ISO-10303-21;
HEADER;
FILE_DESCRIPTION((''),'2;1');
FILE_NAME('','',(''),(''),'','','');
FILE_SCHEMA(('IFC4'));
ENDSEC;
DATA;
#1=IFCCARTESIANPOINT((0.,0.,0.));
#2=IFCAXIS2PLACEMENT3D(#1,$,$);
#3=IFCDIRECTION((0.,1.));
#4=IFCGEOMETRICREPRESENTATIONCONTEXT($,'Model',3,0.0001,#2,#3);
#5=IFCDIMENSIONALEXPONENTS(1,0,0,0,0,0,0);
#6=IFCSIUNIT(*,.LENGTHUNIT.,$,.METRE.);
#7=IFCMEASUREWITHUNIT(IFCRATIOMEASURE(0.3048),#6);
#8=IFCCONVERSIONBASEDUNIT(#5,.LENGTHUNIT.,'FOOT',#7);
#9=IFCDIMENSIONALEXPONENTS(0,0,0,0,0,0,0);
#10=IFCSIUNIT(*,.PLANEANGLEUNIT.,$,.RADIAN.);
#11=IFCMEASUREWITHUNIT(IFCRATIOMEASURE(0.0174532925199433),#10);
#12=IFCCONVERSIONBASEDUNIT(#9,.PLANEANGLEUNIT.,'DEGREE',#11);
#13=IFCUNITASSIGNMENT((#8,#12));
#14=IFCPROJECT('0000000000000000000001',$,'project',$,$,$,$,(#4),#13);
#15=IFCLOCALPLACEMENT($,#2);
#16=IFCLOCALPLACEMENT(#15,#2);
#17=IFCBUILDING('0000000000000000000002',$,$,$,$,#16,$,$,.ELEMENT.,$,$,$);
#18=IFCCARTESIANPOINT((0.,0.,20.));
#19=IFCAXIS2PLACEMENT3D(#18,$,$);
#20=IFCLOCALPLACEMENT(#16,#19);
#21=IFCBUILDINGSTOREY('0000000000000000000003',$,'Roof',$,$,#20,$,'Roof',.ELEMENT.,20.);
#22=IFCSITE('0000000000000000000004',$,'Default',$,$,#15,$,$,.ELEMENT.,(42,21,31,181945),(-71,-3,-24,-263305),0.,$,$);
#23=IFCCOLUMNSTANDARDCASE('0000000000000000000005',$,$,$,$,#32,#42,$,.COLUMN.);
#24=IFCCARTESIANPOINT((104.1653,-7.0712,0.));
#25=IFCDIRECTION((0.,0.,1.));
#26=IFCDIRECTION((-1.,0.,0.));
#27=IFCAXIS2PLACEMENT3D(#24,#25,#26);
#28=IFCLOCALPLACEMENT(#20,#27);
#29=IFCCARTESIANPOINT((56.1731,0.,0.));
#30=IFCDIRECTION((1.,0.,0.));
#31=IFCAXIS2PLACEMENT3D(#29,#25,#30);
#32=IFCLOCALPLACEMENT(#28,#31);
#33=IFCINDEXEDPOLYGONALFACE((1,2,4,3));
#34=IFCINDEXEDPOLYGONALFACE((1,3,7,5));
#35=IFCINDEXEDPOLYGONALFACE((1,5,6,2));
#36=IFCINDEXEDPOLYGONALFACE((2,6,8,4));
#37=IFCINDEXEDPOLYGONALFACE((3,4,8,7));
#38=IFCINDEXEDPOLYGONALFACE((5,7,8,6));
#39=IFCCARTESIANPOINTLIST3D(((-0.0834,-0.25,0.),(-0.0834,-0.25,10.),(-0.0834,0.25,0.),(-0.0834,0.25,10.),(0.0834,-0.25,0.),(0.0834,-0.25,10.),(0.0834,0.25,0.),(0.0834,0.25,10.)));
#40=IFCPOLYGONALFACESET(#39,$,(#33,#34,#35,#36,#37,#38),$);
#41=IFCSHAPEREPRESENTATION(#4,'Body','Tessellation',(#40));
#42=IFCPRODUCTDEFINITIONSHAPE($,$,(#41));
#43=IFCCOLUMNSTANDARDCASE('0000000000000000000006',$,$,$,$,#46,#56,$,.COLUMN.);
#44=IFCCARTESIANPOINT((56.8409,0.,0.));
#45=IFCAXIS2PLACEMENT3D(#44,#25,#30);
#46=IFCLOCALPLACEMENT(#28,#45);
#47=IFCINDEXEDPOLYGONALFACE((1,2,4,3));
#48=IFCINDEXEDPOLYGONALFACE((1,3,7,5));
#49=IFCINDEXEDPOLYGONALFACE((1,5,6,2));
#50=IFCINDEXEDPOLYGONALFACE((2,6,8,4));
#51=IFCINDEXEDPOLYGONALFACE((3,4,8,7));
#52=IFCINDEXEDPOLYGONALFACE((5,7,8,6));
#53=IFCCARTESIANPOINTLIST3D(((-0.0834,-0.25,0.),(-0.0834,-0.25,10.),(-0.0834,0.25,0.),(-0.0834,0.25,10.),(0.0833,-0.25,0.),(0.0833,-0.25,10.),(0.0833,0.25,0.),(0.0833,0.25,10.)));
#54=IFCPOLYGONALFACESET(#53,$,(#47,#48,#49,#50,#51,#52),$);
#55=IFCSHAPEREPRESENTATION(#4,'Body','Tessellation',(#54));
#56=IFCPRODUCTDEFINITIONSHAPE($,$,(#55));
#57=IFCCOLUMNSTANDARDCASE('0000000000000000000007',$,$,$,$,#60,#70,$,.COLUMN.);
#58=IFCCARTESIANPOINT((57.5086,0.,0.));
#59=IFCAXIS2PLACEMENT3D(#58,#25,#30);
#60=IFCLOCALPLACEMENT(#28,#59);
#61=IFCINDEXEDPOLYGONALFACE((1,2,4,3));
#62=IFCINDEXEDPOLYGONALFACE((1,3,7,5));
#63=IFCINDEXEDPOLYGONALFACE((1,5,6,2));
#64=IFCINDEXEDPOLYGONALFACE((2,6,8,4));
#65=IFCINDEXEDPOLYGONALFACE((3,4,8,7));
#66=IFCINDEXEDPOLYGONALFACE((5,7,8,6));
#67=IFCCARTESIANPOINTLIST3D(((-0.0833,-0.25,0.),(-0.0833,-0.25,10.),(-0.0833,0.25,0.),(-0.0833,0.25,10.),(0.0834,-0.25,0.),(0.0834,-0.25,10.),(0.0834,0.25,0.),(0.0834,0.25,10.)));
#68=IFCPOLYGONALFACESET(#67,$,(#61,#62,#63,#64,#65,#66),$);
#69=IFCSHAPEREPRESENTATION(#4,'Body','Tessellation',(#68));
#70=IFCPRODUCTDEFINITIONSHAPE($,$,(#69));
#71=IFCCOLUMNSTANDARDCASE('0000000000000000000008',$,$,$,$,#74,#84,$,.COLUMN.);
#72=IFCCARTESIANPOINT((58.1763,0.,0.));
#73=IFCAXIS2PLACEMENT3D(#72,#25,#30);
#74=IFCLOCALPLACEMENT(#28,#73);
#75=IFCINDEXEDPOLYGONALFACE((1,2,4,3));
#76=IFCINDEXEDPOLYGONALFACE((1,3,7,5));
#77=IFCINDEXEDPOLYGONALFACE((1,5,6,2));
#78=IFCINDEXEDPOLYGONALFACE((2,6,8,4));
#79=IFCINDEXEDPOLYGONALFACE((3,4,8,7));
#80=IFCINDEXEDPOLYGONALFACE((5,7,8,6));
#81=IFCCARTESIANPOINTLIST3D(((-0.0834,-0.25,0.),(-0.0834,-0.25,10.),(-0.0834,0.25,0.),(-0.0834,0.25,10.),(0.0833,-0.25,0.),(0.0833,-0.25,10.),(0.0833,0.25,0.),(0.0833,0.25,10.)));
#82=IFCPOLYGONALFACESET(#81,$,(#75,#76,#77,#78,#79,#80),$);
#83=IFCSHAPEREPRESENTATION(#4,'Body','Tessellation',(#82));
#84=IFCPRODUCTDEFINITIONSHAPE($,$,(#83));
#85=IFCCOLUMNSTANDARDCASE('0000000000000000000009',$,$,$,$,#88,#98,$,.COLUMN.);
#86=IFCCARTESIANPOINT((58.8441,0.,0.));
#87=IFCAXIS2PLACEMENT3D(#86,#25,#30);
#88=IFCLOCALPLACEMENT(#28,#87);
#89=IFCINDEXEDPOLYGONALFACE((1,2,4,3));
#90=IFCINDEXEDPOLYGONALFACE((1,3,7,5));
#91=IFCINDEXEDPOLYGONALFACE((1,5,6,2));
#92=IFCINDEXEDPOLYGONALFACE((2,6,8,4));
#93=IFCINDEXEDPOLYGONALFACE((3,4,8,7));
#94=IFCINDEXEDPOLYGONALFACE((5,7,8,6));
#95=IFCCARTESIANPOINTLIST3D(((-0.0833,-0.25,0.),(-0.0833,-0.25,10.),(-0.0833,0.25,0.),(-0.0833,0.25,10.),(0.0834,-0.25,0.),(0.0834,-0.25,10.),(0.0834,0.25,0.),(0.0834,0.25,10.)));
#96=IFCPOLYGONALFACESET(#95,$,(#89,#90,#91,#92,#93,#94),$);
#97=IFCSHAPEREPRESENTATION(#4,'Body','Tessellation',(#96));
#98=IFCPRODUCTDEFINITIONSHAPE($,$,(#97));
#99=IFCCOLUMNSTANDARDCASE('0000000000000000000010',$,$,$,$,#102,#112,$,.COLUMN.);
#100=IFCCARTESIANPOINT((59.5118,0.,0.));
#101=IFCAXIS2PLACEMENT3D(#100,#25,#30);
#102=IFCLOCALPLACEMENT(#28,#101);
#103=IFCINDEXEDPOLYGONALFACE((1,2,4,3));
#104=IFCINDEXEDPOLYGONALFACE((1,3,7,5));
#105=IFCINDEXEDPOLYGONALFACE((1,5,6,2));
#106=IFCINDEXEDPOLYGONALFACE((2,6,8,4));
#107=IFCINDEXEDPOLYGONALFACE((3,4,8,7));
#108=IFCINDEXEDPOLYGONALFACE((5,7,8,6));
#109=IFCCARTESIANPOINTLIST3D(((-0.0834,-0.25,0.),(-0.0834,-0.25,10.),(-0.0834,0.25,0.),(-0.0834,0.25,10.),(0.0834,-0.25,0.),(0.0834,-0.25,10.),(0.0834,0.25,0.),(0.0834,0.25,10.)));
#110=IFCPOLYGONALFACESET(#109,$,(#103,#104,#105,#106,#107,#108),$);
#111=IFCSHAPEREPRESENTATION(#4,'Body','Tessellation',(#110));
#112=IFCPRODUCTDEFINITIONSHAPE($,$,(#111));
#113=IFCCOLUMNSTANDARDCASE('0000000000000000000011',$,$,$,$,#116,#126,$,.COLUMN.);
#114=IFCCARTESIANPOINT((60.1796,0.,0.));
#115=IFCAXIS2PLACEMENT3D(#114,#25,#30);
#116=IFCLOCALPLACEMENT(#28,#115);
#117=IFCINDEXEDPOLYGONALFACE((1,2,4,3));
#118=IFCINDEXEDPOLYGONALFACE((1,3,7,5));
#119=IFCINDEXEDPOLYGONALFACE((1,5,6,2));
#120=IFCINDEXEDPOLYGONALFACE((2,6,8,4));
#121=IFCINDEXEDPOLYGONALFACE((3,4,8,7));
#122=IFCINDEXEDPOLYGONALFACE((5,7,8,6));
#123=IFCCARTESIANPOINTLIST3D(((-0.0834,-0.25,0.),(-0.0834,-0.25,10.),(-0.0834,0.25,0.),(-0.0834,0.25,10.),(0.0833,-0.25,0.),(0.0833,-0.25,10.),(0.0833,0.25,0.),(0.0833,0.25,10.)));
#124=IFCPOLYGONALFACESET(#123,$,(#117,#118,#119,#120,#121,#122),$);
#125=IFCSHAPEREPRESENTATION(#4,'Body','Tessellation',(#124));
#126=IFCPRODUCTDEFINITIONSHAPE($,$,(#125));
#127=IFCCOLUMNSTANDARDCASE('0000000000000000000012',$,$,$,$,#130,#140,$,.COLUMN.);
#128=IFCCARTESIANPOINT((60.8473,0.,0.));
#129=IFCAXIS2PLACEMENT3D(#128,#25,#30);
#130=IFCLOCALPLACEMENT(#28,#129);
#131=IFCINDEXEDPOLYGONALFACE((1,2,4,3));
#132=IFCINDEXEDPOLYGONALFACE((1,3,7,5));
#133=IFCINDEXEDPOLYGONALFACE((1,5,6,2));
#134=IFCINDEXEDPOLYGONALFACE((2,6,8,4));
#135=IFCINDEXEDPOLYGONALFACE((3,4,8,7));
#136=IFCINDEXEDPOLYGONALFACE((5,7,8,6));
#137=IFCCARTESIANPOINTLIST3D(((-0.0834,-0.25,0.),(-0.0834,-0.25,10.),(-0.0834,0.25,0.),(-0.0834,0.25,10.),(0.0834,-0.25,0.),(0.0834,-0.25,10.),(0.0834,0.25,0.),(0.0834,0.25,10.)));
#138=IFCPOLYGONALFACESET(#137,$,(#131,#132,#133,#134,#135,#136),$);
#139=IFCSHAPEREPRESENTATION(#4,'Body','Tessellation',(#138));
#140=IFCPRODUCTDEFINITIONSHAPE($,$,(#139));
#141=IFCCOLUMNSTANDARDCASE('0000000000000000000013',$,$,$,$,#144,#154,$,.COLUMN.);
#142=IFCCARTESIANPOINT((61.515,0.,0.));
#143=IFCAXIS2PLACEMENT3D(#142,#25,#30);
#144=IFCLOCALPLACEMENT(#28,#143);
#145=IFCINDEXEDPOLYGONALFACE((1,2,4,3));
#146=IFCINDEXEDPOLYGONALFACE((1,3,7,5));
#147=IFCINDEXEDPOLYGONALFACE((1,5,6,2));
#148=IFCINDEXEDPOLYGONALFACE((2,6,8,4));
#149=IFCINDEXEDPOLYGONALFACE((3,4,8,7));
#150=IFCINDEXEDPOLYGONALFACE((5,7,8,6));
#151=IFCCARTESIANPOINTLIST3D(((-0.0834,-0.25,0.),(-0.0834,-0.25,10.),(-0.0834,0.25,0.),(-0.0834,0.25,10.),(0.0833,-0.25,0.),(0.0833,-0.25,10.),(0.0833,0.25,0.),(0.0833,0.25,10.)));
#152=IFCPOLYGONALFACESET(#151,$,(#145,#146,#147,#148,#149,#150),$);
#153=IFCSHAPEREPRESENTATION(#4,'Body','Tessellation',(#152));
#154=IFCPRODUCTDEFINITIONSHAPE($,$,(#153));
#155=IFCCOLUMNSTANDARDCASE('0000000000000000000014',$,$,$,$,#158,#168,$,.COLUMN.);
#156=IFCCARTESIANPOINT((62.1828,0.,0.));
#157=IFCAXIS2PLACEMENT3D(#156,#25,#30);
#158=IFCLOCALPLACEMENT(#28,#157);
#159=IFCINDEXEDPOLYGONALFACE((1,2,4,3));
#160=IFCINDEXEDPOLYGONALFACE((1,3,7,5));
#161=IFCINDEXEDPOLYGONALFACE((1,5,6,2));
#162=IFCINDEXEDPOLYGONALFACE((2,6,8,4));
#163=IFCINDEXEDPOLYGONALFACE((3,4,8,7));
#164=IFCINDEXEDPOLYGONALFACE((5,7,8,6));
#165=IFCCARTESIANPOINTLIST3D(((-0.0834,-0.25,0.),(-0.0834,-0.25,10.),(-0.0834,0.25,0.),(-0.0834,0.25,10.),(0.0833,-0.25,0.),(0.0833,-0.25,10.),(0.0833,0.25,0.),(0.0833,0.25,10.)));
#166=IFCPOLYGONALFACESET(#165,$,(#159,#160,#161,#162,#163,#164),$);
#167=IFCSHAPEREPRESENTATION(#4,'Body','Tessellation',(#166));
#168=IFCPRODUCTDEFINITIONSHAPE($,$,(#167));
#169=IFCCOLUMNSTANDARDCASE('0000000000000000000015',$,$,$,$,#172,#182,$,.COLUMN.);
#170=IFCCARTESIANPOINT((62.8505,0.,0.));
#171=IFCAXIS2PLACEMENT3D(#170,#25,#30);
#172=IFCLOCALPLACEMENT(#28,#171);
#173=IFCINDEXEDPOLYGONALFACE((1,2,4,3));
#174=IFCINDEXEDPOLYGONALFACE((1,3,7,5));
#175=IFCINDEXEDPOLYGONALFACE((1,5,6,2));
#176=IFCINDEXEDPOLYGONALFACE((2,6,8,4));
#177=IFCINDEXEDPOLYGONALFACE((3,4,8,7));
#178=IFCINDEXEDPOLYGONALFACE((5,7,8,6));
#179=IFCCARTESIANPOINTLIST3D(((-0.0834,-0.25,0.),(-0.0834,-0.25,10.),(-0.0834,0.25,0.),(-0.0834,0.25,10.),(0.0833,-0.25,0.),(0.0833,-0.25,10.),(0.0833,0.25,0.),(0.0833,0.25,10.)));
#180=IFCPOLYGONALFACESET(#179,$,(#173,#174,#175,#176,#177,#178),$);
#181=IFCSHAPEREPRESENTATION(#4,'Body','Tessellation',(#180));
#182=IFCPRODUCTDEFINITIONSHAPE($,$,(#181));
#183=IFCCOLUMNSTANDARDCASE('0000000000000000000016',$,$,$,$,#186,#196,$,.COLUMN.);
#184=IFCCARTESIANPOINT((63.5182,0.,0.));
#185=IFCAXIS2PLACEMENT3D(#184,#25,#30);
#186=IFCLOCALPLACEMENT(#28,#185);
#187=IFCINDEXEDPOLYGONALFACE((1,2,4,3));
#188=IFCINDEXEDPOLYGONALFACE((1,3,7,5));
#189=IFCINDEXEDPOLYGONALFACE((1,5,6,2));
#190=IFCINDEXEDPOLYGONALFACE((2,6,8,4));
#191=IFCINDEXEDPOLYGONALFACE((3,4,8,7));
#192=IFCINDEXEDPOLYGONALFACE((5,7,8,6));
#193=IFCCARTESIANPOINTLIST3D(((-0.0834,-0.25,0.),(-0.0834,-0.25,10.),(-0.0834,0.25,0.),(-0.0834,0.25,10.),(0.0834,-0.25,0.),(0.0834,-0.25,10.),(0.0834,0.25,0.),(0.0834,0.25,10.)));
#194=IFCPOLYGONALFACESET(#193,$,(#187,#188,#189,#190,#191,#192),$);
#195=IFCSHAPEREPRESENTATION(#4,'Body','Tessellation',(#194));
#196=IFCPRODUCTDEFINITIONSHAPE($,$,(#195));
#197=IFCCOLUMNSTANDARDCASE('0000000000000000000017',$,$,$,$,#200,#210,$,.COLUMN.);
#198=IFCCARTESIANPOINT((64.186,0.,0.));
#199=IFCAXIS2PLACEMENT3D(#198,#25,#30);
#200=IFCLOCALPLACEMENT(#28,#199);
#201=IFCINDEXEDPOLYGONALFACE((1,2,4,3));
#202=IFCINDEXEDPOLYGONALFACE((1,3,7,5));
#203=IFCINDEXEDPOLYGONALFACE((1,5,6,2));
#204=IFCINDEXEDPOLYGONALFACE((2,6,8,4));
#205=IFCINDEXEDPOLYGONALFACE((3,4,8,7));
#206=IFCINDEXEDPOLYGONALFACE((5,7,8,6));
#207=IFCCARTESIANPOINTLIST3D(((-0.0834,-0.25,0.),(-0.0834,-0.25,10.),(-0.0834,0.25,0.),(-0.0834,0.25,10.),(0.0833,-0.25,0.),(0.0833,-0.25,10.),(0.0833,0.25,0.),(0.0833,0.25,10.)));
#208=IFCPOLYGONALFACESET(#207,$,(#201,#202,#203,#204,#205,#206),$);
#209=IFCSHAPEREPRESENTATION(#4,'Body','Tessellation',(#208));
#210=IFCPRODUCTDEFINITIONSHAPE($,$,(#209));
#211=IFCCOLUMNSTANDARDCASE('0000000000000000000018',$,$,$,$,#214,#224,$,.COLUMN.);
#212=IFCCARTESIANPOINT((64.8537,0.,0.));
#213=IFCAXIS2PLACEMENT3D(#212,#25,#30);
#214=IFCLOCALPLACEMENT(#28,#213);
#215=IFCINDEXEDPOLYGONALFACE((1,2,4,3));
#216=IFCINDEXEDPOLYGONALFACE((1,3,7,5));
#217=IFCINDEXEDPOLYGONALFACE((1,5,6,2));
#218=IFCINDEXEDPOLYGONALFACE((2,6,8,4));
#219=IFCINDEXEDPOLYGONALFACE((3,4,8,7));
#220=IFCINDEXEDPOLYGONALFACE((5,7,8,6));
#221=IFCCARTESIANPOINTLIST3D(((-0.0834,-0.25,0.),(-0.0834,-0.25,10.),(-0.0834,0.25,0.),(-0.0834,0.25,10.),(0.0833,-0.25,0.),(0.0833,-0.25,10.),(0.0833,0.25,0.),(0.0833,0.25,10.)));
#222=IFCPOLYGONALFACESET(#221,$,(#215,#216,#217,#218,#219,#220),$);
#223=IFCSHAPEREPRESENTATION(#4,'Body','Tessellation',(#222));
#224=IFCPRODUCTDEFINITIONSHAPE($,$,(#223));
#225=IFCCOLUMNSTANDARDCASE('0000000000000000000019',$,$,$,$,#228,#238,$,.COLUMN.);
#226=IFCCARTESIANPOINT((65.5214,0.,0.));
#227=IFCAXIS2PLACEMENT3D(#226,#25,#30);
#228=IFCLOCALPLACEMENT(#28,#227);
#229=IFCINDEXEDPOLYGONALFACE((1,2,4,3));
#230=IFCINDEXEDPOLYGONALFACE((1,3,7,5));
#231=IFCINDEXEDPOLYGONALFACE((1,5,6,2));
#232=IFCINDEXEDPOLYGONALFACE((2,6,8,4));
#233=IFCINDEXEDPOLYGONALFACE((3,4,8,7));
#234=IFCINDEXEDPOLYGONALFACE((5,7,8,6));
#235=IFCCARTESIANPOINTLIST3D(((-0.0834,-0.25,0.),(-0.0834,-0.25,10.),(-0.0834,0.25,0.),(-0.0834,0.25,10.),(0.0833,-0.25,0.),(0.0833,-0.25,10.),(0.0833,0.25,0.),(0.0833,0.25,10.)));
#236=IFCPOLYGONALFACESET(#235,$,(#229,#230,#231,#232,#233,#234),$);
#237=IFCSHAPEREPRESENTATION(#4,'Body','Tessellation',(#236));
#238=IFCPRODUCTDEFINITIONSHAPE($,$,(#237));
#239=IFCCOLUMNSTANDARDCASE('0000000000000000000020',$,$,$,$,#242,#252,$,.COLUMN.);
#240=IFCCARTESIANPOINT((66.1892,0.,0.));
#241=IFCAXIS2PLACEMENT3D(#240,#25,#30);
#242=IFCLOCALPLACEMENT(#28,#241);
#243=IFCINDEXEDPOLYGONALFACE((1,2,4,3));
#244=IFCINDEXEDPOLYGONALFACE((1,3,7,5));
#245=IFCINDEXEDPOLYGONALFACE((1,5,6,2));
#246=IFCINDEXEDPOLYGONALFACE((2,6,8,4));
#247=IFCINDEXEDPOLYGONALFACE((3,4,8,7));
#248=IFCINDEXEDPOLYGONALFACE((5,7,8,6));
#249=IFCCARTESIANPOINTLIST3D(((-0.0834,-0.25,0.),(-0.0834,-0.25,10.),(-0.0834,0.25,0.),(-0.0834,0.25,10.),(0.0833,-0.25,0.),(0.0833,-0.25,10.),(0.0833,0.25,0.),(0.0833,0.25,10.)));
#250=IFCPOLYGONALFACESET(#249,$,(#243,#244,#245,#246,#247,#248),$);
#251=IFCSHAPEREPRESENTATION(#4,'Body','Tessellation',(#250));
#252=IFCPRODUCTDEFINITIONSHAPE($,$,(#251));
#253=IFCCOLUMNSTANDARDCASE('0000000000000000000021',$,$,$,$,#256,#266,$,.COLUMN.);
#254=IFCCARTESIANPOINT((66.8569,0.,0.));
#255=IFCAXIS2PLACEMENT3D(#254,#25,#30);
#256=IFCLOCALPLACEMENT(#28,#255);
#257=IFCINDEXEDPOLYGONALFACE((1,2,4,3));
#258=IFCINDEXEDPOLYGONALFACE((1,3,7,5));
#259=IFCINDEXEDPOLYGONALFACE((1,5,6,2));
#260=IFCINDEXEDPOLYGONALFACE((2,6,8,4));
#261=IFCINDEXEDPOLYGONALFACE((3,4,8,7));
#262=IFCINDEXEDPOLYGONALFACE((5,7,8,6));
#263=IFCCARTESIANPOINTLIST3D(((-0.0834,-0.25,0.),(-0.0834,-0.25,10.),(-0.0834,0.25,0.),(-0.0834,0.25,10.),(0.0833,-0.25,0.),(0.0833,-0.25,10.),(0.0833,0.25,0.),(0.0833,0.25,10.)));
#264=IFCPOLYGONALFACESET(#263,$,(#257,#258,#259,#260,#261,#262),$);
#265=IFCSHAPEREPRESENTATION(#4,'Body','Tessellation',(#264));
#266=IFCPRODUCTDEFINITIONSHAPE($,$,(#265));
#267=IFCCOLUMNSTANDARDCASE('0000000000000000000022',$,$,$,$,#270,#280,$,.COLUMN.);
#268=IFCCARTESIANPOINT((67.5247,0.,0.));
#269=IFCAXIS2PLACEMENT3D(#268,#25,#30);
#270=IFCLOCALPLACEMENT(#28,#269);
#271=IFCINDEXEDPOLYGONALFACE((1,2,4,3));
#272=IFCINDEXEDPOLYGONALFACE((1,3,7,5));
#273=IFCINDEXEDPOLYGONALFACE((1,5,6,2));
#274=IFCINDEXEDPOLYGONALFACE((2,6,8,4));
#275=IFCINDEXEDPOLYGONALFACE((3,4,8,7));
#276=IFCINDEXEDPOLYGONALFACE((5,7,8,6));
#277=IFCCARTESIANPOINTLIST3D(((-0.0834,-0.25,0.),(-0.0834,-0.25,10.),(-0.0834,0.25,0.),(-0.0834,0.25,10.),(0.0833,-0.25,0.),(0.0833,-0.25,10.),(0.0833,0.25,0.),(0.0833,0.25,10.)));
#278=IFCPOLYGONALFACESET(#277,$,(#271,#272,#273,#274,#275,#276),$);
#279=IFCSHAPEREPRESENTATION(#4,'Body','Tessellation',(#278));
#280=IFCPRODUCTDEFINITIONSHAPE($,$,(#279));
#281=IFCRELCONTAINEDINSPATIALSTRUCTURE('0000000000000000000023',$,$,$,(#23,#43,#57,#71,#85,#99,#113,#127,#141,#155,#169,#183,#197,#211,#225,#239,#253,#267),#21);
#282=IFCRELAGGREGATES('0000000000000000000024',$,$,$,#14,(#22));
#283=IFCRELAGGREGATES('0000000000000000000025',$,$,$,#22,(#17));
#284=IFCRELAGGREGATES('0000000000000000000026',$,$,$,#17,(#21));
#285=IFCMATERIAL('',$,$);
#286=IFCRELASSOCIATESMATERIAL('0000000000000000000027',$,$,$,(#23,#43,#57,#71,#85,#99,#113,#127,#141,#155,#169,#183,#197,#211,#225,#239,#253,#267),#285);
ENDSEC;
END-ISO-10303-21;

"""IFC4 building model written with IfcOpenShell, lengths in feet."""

from ifc_helpers import new_model, entity, si_unit, converted_unit, direction, frame, origin, place, context, project, spatial, rectangle, extrude, material, element, save


model = new_model("IFC4")

# Units and contexts
model_context = context("Model", 3, precision=0.0001, world=origin(), true_north=direction((0.0, 1.0)))
ifc_project = project(units=[converted_unit("LENGTHUNIT", "FOOT", entity("IfcRatioMeasure", 0.3048), si_unit("LENGTHUNIT", "METRE"), dimensions=[1, 0, 0, 0, 0, 0, 0]), converted_unit("PLANEANGLEUNIT", "DEGREE", entity("IfcRatioMeasure", 0.0174532925199433), si_unit("PLANEANGLEUNIT", "RADIAN"), dimensions=[0, 0, 0, 0, 0, 0, 0])], contexts=[model_context])

# Site, building, storey
site_placement = place(None, origin())
site = spatial("IfcSite", under=ifc_project, at=site_placement, Name="Default", CompositionType="ELEMENT", RefLatitude=(42, 21, 31, 181945), RefLongitude=(-71, -3, -24, -263305), RefElevation=0.0)
building_placement = place(site_placement, origin())
building = spatial("IfcBuilding", under=site, at=building_placement, CompositionType="ELEMENT")
storey_placement = place(building_placement, frame((0.0, 0.0, 20.0)))
storey = spatial("IfcBuildingStorey", under=building, at=storey_placement, Name="Roof", LongName="Roof", CompositionType="ELEMENT", Elevation=20.0)

# Columns
ifc_material_1 = material(Name="")
placement_1 = place(storey_placement, frame((104.1653, -7.0712, 0.0), z_axis=(0.0, 0.0, 1.0), x_axis=(-1.0, 0.0, 0.0)))
for number, where, z_axis, x_axis in (
    (1, (56.1731, 0.0, 0.0), (0.0, 0.0, 1.0), (1.0, 0.0, 0.0)),
    (2, (56.8409, 0.0, 0.0), (0.0, 0.0, 1.0), (1.0, 0.0, 0.0)),
    (3, (57.5086, 0.0, 0.0), (0.0, 0.0, 1.0), (1.0, 0.0, 0.0)),
    (4, (58.1763, 0.0, 0.0), (0.0, 0.0, 1.0), (1.0, 0.0, 0.0)),
    (5, (58.8441, 0.0, 0.0), (0.0, 0.0, 1.0), (1.0, 0.0, 0.0)),
    (6, (59.5118, 0.0, 0.0), (0.0, 0.0, 1.0), (1.0, 0.0, 0.0)),
    (7, (60.1796, 0.0, 0.0), (0.0, 0.0, 1.0), (1.0, 0.0, 0.0)),
    (8, (60.8473, 0.0, 0.0), (0.0, 0.0, 1.0), (1.0, 0.0, 0.0)),
    (9, (61.515, 0.0, 0.0), (0.0, 0.0, 1.0), (1.0, 0.0, 0.0)),
    (10, (62.1828, 0.0, 0.0), (0.0, 0.0, 1.0), (1.0, 0.0, 0.0)),
    (11, (62.8505, 0.0, 0.0), (0.0, 0.0, 1.0), (1.0, 0.0, 0.0)),
    (12, (63.5182, 0.0, 0.0), (0.0, 0.0, 1.0), (1.0, 0.0, 0.0)),
    (13, (64.186, 0.0, 0.0), (0.0, 0.0, 1.0), (1.0, 0.0, 0.0)),
    (14, (64.8537, 0.0, 0.0), (0.0, 0.0, 1.0), (1.0, 0.0, 0.0)),
    (15, (65.5214, 0.0, 0.0), (0.0, 0.0, 1.0), (1.0, 0.0, 0.0)),
    (16, (66.1892, 0.0, 0.0), (0.0, 0.0, 1.0), (1.0, 0.0, 0.0)),
    (17, (66.8569, 0.0, 0.0), (0.0, 0.0, 1.0), (1.0, 0.0, 0.0)),
    (18, (67.5247, 0.0, 0.0), (0.0, 0.0, 1.0), (1.0, 0.0, 0.0)),
):
    element("IfcColumnStandardCase", number, at=place(placement_1, frame(where, z_axis=z_axis, x_axis=x_axis)), inside=storey, material=ifc_material_1, PredefinedType="COLUMN", context=model_context, shape_type="SweptSolid", body=[
        extrude(rectangle(XDim=0.1667, YDim=0.5), origin(), (0.0, 0.0, 1.0), 10.0),
    ])

save(model, "model.ifc")
